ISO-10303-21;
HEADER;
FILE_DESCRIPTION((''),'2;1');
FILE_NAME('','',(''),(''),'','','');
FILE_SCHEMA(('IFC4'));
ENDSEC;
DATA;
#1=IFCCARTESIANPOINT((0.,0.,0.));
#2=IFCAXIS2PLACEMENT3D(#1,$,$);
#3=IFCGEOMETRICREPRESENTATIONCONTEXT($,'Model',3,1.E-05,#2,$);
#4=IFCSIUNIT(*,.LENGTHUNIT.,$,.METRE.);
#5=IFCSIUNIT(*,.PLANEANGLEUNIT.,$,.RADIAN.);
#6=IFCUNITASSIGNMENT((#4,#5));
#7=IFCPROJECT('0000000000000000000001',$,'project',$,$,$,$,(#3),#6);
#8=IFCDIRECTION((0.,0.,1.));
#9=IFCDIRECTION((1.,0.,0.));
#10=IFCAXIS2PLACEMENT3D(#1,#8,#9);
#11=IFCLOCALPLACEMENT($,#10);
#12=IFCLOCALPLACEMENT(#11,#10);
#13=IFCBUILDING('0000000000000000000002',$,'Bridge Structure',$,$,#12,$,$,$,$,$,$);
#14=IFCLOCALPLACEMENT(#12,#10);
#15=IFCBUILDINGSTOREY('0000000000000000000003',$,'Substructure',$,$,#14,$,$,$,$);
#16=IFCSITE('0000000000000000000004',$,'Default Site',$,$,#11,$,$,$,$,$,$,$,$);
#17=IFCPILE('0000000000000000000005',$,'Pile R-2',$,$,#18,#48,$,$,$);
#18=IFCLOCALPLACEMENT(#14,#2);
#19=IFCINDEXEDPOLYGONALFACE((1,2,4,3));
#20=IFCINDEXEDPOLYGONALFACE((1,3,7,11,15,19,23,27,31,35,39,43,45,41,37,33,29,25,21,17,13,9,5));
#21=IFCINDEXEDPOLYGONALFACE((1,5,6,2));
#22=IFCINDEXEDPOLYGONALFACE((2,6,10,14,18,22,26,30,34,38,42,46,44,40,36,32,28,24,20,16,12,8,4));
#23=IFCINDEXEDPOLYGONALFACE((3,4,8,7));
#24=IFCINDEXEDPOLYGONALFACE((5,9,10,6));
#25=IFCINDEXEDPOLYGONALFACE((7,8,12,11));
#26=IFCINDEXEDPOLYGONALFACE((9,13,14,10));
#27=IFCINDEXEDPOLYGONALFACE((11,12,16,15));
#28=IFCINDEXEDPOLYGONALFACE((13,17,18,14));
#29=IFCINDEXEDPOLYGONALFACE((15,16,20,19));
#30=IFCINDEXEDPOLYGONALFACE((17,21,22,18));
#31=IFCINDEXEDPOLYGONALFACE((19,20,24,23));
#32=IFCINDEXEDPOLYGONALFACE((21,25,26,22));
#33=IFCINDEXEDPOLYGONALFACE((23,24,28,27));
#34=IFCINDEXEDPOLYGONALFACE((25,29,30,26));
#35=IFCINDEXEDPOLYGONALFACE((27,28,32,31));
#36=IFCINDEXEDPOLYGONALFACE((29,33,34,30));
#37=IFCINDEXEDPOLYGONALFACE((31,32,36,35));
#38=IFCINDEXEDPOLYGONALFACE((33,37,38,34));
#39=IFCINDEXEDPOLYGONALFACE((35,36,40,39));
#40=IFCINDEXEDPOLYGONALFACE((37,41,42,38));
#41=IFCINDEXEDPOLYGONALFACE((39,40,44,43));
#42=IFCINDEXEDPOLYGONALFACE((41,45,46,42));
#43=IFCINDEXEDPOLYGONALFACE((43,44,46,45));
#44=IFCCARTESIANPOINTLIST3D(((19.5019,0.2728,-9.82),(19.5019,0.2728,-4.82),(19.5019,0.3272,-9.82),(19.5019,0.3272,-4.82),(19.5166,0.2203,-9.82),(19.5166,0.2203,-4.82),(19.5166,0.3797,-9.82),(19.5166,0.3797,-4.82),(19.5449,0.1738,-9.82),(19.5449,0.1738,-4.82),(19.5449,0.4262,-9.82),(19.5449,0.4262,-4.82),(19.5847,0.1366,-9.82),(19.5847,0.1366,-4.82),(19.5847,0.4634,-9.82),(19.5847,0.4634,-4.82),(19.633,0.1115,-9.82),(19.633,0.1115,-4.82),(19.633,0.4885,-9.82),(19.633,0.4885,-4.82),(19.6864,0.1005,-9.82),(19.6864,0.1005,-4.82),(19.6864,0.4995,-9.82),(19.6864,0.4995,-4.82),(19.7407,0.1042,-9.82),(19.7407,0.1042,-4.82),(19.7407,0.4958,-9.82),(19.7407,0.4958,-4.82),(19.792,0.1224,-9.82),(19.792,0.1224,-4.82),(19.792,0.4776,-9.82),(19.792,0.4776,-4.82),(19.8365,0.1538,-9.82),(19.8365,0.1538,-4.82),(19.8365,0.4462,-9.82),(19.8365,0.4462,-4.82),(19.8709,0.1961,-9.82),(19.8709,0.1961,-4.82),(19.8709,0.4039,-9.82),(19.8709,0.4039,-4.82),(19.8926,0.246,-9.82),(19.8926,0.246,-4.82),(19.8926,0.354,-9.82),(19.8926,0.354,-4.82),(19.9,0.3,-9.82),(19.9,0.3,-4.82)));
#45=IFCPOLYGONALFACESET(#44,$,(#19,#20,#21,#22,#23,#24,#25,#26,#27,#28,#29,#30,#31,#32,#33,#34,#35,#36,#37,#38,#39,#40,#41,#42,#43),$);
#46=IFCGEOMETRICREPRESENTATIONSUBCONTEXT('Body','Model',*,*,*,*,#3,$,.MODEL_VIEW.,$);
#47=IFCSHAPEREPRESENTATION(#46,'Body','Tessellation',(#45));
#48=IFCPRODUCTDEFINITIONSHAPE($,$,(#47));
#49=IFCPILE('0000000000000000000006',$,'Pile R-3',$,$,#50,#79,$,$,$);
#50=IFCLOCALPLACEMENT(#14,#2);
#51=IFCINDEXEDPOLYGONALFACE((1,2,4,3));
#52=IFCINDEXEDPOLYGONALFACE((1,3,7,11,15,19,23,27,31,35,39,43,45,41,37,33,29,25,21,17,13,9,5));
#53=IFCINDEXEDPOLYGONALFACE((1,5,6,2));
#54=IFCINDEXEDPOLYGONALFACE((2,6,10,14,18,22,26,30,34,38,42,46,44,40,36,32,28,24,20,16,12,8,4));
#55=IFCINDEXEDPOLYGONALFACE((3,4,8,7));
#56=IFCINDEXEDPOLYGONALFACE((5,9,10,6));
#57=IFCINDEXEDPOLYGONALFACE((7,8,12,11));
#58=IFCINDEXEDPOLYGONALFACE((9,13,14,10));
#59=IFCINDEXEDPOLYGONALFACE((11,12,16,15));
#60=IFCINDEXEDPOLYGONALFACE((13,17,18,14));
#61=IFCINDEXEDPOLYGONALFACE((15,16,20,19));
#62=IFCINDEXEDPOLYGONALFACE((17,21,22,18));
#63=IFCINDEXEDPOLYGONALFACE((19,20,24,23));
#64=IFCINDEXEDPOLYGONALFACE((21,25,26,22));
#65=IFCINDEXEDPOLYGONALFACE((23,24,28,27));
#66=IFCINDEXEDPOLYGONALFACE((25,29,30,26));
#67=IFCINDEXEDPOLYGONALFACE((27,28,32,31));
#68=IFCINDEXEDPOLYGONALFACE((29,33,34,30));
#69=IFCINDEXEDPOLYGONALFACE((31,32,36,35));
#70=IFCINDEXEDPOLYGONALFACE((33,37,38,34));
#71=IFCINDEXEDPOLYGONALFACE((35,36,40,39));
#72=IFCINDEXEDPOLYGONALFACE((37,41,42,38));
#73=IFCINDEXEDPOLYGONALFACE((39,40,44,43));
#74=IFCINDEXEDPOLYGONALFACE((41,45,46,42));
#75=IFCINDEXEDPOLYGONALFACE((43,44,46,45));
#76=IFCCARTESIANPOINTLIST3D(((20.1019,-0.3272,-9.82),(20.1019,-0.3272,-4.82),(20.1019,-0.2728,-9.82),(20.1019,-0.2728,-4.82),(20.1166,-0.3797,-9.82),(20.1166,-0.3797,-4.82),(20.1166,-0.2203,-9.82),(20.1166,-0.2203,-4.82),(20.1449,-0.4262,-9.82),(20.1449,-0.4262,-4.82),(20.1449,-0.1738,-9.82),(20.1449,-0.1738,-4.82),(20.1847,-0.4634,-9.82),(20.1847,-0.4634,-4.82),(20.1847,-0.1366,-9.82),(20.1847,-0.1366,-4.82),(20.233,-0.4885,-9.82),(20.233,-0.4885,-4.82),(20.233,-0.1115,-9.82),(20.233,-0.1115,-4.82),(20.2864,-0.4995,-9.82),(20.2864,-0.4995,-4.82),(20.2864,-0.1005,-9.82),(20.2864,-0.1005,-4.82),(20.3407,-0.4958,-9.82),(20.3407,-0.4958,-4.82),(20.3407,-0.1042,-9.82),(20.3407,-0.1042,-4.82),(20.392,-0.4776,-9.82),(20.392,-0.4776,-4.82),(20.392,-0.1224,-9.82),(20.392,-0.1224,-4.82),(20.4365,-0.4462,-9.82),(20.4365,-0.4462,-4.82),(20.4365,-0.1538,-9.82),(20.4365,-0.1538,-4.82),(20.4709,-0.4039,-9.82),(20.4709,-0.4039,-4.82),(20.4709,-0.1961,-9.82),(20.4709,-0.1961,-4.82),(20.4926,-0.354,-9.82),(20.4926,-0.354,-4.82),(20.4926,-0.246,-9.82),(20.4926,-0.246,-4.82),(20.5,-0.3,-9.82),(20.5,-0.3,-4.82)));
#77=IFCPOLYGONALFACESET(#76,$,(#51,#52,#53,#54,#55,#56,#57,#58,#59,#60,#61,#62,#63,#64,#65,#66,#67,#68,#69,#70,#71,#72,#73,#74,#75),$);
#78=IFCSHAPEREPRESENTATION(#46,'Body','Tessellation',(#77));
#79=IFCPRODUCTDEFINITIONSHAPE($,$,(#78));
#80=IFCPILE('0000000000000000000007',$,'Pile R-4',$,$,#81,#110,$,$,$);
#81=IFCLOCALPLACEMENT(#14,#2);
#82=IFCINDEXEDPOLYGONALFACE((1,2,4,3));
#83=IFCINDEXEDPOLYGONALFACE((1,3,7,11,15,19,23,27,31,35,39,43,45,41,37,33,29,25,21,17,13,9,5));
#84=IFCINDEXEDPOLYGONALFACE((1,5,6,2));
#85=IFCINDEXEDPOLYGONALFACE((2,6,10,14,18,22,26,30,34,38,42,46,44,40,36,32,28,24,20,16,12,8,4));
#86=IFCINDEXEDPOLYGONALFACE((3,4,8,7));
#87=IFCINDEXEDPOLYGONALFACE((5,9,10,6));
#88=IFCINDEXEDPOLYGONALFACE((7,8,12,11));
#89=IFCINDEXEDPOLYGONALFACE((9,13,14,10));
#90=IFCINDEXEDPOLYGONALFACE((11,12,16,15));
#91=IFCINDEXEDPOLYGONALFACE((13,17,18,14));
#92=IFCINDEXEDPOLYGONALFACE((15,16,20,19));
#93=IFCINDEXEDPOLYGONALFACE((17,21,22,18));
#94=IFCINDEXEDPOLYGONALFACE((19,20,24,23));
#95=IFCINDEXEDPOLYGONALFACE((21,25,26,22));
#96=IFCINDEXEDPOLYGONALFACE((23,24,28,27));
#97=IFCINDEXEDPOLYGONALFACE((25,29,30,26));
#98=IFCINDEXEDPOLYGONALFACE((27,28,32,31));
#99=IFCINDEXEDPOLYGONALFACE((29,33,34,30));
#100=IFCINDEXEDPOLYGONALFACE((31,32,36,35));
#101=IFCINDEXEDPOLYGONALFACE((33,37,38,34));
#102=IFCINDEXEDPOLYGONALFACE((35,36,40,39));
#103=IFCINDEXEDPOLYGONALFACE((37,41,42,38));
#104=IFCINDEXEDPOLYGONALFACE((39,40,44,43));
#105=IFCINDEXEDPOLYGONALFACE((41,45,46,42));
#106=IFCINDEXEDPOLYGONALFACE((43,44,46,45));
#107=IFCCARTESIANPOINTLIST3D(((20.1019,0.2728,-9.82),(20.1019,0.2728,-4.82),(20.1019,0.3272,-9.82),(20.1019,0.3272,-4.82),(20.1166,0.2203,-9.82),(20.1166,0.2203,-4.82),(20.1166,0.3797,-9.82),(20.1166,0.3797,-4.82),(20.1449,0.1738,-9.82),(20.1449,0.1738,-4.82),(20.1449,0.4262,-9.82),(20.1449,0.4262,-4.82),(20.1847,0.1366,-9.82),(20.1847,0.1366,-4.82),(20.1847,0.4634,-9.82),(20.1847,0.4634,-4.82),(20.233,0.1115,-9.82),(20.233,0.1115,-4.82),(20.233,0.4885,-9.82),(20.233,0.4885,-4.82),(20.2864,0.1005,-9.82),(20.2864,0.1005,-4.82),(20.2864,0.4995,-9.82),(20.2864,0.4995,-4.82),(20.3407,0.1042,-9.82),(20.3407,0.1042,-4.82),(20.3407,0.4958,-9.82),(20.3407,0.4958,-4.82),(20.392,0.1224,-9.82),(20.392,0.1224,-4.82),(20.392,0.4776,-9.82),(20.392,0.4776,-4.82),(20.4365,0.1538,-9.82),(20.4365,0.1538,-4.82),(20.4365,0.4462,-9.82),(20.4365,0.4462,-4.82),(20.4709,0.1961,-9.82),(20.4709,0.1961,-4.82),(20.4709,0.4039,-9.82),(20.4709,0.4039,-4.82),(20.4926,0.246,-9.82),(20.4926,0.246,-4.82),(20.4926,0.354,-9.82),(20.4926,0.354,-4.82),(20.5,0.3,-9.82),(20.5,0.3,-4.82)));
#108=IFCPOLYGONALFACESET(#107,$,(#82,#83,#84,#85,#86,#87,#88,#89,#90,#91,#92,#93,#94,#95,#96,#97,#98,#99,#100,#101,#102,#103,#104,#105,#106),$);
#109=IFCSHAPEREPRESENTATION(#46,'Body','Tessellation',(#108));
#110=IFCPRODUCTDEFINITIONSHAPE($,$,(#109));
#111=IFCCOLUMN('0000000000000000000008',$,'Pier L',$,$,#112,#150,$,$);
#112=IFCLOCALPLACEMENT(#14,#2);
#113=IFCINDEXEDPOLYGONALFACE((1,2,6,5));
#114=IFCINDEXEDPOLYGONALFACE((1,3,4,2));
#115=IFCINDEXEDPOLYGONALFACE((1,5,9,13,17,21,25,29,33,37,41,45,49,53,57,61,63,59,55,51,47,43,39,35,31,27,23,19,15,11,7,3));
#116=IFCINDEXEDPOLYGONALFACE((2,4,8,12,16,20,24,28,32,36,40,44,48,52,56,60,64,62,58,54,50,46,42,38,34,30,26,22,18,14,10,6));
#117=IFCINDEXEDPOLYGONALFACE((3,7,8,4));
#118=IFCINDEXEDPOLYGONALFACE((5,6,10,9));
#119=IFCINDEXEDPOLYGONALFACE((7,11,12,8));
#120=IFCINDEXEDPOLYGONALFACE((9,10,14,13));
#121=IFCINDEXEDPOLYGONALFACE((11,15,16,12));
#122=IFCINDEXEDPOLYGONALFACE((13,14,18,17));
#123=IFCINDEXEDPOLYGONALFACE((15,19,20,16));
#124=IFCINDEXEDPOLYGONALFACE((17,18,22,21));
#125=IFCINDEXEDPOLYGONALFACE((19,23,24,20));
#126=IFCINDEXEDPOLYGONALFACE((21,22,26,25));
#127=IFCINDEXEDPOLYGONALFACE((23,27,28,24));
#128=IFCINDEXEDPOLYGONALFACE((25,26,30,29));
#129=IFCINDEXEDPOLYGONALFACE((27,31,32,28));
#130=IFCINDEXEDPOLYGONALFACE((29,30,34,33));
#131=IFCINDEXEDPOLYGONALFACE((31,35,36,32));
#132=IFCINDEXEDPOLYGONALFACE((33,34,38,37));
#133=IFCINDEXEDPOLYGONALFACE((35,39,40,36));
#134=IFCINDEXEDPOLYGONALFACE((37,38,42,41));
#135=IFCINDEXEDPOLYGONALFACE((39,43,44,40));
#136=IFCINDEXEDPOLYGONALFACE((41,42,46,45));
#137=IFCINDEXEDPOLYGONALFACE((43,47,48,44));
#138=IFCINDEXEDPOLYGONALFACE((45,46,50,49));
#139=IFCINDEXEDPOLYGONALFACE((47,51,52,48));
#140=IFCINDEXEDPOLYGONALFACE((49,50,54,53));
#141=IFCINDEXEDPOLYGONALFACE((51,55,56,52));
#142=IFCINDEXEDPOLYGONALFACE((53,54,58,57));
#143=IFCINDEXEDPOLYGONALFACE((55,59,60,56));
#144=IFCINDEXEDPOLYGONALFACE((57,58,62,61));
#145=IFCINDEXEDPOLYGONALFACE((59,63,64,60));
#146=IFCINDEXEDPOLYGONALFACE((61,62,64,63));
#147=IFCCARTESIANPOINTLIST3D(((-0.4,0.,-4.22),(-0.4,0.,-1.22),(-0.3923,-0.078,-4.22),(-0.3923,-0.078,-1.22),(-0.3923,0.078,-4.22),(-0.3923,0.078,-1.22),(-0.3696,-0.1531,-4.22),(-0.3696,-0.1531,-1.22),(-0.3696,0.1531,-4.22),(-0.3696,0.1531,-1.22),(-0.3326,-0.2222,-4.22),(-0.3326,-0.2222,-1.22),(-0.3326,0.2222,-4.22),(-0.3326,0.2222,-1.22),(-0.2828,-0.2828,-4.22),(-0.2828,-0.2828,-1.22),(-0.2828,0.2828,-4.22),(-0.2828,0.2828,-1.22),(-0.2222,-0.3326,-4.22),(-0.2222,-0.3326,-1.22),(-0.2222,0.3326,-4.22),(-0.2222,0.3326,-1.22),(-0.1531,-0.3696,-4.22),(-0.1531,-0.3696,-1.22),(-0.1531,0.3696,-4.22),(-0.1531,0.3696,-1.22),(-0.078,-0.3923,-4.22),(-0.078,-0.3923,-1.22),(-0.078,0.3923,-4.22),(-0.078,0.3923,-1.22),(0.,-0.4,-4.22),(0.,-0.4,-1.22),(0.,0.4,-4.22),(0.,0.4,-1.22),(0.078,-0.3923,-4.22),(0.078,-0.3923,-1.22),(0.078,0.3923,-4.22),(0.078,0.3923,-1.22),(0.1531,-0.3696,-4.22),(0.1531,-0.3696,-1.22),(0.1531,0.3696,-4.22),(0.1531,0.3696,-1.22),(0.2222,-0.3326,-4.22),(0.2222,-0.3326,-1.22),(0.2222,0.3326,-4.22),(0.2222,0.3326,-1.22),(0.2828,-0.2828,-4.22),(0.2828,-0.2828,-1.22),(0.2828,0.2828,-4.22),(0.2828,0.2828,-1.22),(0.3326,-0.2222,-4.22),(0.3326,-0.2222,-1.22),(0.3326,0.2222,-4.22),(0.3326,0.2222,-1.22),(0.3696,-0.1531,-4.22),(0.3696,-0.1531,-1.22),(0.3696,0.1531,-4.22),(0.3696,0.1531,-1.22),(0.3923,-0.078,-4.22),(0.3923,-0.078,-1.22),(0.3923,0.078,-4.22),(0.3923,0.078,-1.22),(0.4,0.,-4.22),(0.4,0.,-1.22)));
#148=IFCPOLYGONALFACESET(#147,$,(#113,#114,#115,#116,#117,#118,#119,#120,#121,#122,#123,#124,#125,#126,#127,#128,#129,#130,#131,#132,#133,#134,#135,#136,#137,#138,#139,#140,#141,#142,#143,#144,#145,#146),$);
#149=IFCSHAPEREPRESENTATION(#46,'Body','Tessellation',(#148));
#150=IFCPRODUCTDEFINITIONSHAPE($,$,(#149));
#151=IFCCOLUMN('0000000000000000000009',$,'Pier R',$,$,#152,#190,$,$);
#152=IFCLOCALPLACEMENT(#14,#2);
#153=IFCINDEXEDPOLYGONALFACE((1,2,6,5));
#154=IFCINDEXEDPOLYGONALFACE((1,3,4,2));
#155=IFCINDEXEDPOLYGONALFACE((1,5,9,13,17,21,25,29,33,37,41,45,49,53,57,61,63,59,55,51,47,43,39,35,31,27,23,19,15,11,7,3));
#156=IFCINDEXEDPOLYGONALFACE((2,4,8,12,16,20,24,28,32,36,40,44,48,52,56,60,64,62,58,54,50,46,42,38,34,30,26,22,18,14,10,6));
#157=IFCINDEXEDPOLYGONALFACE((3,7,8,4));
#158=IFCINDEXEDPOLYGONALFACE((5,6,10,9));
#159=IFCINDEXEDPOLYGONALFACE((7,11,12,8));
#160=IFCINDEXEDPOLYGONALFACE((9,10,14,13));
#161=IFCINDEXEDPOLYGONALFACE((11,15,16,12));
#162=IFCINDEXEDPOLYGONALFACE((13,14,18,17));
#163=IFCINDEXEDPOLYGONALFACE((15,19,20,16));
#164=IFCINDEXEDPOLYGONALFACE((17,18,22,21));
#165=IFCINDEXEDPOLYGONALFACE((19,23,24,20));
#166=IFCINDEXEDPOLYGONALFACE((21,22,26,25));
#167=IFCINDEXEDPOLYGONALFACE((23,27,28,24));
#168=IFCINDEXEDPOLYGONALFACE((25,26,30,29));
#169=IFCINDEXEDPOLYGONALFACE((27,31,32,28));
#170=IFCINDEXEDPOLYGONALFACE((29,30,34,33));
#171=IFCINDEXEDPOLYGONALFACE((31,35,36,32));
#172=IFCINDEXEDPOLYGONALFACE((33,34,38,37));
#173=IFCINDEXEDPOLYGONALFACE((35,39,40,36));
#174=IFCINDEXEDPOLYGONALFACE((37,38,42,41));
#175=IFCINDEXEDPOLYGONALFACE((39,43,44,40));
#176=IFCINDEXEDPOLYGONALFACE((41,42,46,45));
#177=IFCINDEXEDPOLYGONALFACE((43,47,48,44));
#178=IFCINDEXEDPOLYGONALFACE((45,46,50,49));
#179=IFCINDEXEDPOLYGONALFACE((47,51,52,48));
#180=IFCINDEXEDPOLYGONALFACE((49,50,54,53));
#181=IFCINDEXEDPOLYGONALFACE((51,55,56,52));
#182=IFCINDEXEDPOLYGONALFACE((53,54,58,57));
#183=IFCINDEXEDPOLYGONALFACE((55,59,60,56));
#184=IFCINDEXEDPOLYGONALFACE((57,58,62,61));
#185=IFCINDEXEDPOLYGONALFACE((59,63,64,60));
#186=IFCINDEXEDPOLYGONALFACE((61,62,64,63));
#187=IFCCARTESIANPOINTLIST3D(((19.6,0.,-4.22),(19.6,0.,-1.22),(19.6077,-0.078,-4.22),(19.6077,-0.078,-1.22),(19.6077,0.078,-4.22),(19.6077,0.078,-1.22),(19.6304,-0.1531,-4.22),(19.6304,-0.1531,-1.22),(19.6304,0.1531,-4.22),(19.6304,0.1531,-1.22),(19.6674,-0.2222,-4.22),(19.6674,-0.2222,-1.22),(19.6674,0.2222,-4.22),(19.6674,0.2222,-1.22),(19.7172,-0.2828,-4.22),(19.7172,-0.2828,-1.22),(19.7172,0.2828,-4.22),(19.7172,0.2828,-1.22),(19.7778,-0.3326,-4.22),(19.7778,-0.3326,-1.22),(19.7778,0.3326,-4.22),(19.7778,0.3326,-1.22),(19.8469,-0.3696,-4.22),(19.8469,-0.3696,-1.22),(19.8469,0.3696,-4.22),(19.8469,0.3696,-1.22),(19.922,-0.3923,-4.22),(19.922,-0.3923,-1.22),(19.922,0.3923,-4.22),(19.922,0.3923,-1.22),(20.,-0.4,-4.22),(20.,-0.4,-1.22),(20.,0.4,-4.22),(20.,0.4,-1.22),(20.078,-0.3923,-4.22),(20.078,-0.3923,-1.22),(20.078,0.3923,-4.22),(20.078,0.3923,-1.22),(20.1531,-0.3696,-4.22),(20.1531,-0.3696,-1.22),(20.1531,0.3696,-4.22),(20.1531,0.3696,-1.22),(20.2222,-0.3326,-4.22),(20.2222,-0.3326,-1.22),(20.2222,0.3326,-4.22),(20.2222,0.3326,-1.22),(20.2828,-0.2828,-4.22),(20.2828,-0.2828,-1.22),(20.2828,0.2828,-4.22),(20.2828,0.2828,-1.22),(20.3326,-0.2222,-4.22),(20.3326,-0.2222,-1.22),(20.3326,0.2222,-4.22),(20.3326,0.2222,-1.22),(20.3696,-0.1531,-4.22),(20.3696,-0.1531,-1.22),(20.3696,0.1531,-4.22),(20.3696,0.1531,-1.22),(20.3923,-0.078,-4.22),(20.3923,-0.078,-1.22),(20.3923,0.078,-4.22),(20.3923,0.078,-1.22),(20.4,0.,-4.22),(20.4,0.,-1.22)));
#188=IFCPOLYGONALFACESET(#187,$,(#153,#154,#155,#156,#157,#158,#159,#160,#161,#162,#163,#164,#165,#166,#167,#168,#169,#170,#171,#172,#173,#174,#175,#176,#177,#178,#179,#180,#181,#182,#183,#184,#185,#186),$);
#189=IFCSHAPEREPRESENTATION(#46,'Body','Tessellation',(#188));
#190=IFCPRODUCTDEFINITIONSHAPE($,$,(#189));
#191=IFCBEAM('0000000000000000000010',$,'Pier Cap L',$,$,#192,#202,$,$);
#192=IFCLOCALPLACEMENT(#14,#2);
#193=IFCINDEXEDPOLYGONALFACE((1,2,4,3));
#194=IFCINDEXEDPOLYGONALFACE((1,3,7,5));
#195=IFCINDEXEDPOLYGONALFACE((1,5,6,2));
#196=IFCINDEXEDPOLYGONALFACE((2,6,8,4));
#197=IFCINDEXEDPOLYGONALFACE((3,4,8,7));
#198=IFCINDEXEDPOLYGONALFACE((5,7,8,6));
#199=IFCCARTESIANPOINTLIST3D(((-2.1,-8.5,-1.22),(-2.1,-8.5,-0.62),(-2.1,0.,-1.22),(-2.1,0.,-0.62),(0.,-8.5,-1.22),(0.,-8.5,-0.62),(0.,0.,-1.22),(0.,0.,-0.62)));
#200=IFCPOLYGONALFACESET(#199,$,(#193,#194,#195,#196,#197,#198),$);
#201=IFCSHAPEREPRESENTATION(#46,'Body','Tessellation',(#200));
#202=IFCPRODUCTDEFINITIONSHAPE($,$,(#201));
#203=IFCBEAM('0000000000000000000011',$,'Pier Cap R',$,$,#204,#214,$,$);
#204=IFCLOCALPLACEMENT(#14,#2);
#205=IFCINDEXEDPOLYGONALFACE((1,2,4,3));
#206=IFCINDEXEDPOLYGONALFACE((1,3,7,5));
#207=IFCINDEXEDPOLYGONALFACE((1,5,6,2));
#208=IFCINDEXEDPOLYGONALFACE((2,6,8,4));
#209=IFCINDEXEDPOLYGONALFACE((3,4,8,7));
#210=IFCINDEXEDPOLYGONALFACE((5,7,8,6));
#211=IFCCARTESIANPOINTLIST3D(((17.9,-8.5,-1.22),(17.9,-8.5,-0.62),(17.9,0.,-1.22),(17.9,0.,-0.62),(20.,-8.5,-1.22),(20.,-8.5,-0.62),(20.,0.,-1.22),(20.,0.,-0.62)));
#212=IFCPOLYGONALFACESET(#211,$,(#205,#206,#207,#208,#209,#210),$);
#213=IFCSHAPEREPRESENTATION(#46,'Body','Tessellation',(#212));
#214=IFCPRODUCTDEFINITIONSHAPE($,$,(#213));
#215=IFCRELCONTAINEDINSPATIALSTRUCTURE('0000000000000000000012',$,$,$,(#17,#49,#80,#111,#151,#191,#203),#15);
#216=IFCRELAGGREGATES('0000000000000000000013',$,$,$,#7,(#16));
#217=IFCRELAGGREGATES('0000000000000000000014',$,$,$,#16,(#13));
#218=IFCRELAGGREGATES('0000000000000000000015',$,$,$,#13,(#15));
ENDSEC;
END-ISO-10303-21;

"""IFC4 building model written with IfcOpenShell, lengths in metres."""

from ifc_helpers import new_model, si_unit, frame, origin, origin_with_axes, origin_2d_with_axis, place, context, subcontext, project, spatial, rectangle, circle, extrude, element, save


model = new_model("IFC4")

# Units and contexts
model_context = context("Model", 3, precision=1e-05, world=origin())
body_context = subcontext(model_context, "Body", "Model", "MODEL_VIEW")
ifc_project = project(units=[si_unit("LENGTHUNIT", "METRE"), si_unit("PLANEANGLEUNIT", "RADIAN")], contexts=[model_context])

# Site, building, storey
site_placement = place(None, origin_with_axes())
site = spatial("IfcSite", under=ifc_project, at=site_placement, Name="Default Site")
building_placement = place(site_placement, origin_with_axes())
building = spatial("IfcBuilding", under=site, at=building_placement, Name="Bridge Structure")
storey_placement = place(building_placement, origin_with_axes())
storey = spatial("IfcBuildingStorey", under=building, at=storey_placement, Name="Substructure")

# Piles
for number, where, z_axis, x_axis, name in (
    (1, (19.7, 0.3, -9.82), (0.0, 0.0, 1.0), (1.0, 0.0, 0.0), "Pile R-2"),
    (2, (20.3, -0.3, -9.82), (0.0, 0.0, 1.0), (1.0, 0.0, 0.0), "Pile R-3"),
    (3, (20.3, 0.3, -9.82), (0.0, 0.0, 1.0), (1.0, 0.0, 0.0), "Pile R-4"),
):
    element("IfcPile", number, at=place(storey_placement, frame(where, z_axis=z_axis, x_axis=x_axis)), inside=storey, Name=name, context=body_context, shape_type="SweptSolid", body=[
        extrude(circle(Radius=0.2, at=origin_2d_with_axis()), origin_with_axes(), (0.0, 0.0, 1.0), 5.0),
    ])

# Columns
for number, where, z_axis, x_axis, name in (
    (4, (0.0, 0.0, -4.22), (0.0, 0.0, 1.0), (1.0, 0.0, 0.0), "Pier L"),
    (5, (20.0, 0.0, -4.22), (0.0, 0.0, 1.0), (1.0, 0.0, 0.0), "Pier R"),
):
    element("IfcColumn", number, at=place(storey_placement, frame(where, z_axis=z_axis, x_axis=x_axis)), inside=storey, Name=name, context=body_context, shape_type="SweptSolid", body=[
        extrude(circle(Radius=0.4, at=origin_2d_with_axis()), origin_with_axes(), (0.0, 0.0, 1.0), 3.0),
    ])

# Beams
for number, where, z_axis, x_axis, name in (
    (6, (-1.05, -4.25, -1.22), (0.0, 0.0, 1.0), (1.0, 0.0, 0.0), "Pier Cap L"),
    (7, (18.95, -4.25, -1.22), (0.0, 0.0, 1.0), (1.0, 0.0, 0.0), "Pier Cap R"),
):
    element("IfcBeam", number, at=place(storey_placement, frame(where, z_axis=z_axis, x_axis=x_axis)), inside=storey, Name=name, context=body_context, shape_type="SweptSolid", body=[
        extrude(rectangle(XDim=2.1, YDim=8.5, at=origin_2d_with_axis()), origin_with_axes(), (0.0, 0.0, 1.0), 0.6),
    ])

save(model, "model.ifc")
